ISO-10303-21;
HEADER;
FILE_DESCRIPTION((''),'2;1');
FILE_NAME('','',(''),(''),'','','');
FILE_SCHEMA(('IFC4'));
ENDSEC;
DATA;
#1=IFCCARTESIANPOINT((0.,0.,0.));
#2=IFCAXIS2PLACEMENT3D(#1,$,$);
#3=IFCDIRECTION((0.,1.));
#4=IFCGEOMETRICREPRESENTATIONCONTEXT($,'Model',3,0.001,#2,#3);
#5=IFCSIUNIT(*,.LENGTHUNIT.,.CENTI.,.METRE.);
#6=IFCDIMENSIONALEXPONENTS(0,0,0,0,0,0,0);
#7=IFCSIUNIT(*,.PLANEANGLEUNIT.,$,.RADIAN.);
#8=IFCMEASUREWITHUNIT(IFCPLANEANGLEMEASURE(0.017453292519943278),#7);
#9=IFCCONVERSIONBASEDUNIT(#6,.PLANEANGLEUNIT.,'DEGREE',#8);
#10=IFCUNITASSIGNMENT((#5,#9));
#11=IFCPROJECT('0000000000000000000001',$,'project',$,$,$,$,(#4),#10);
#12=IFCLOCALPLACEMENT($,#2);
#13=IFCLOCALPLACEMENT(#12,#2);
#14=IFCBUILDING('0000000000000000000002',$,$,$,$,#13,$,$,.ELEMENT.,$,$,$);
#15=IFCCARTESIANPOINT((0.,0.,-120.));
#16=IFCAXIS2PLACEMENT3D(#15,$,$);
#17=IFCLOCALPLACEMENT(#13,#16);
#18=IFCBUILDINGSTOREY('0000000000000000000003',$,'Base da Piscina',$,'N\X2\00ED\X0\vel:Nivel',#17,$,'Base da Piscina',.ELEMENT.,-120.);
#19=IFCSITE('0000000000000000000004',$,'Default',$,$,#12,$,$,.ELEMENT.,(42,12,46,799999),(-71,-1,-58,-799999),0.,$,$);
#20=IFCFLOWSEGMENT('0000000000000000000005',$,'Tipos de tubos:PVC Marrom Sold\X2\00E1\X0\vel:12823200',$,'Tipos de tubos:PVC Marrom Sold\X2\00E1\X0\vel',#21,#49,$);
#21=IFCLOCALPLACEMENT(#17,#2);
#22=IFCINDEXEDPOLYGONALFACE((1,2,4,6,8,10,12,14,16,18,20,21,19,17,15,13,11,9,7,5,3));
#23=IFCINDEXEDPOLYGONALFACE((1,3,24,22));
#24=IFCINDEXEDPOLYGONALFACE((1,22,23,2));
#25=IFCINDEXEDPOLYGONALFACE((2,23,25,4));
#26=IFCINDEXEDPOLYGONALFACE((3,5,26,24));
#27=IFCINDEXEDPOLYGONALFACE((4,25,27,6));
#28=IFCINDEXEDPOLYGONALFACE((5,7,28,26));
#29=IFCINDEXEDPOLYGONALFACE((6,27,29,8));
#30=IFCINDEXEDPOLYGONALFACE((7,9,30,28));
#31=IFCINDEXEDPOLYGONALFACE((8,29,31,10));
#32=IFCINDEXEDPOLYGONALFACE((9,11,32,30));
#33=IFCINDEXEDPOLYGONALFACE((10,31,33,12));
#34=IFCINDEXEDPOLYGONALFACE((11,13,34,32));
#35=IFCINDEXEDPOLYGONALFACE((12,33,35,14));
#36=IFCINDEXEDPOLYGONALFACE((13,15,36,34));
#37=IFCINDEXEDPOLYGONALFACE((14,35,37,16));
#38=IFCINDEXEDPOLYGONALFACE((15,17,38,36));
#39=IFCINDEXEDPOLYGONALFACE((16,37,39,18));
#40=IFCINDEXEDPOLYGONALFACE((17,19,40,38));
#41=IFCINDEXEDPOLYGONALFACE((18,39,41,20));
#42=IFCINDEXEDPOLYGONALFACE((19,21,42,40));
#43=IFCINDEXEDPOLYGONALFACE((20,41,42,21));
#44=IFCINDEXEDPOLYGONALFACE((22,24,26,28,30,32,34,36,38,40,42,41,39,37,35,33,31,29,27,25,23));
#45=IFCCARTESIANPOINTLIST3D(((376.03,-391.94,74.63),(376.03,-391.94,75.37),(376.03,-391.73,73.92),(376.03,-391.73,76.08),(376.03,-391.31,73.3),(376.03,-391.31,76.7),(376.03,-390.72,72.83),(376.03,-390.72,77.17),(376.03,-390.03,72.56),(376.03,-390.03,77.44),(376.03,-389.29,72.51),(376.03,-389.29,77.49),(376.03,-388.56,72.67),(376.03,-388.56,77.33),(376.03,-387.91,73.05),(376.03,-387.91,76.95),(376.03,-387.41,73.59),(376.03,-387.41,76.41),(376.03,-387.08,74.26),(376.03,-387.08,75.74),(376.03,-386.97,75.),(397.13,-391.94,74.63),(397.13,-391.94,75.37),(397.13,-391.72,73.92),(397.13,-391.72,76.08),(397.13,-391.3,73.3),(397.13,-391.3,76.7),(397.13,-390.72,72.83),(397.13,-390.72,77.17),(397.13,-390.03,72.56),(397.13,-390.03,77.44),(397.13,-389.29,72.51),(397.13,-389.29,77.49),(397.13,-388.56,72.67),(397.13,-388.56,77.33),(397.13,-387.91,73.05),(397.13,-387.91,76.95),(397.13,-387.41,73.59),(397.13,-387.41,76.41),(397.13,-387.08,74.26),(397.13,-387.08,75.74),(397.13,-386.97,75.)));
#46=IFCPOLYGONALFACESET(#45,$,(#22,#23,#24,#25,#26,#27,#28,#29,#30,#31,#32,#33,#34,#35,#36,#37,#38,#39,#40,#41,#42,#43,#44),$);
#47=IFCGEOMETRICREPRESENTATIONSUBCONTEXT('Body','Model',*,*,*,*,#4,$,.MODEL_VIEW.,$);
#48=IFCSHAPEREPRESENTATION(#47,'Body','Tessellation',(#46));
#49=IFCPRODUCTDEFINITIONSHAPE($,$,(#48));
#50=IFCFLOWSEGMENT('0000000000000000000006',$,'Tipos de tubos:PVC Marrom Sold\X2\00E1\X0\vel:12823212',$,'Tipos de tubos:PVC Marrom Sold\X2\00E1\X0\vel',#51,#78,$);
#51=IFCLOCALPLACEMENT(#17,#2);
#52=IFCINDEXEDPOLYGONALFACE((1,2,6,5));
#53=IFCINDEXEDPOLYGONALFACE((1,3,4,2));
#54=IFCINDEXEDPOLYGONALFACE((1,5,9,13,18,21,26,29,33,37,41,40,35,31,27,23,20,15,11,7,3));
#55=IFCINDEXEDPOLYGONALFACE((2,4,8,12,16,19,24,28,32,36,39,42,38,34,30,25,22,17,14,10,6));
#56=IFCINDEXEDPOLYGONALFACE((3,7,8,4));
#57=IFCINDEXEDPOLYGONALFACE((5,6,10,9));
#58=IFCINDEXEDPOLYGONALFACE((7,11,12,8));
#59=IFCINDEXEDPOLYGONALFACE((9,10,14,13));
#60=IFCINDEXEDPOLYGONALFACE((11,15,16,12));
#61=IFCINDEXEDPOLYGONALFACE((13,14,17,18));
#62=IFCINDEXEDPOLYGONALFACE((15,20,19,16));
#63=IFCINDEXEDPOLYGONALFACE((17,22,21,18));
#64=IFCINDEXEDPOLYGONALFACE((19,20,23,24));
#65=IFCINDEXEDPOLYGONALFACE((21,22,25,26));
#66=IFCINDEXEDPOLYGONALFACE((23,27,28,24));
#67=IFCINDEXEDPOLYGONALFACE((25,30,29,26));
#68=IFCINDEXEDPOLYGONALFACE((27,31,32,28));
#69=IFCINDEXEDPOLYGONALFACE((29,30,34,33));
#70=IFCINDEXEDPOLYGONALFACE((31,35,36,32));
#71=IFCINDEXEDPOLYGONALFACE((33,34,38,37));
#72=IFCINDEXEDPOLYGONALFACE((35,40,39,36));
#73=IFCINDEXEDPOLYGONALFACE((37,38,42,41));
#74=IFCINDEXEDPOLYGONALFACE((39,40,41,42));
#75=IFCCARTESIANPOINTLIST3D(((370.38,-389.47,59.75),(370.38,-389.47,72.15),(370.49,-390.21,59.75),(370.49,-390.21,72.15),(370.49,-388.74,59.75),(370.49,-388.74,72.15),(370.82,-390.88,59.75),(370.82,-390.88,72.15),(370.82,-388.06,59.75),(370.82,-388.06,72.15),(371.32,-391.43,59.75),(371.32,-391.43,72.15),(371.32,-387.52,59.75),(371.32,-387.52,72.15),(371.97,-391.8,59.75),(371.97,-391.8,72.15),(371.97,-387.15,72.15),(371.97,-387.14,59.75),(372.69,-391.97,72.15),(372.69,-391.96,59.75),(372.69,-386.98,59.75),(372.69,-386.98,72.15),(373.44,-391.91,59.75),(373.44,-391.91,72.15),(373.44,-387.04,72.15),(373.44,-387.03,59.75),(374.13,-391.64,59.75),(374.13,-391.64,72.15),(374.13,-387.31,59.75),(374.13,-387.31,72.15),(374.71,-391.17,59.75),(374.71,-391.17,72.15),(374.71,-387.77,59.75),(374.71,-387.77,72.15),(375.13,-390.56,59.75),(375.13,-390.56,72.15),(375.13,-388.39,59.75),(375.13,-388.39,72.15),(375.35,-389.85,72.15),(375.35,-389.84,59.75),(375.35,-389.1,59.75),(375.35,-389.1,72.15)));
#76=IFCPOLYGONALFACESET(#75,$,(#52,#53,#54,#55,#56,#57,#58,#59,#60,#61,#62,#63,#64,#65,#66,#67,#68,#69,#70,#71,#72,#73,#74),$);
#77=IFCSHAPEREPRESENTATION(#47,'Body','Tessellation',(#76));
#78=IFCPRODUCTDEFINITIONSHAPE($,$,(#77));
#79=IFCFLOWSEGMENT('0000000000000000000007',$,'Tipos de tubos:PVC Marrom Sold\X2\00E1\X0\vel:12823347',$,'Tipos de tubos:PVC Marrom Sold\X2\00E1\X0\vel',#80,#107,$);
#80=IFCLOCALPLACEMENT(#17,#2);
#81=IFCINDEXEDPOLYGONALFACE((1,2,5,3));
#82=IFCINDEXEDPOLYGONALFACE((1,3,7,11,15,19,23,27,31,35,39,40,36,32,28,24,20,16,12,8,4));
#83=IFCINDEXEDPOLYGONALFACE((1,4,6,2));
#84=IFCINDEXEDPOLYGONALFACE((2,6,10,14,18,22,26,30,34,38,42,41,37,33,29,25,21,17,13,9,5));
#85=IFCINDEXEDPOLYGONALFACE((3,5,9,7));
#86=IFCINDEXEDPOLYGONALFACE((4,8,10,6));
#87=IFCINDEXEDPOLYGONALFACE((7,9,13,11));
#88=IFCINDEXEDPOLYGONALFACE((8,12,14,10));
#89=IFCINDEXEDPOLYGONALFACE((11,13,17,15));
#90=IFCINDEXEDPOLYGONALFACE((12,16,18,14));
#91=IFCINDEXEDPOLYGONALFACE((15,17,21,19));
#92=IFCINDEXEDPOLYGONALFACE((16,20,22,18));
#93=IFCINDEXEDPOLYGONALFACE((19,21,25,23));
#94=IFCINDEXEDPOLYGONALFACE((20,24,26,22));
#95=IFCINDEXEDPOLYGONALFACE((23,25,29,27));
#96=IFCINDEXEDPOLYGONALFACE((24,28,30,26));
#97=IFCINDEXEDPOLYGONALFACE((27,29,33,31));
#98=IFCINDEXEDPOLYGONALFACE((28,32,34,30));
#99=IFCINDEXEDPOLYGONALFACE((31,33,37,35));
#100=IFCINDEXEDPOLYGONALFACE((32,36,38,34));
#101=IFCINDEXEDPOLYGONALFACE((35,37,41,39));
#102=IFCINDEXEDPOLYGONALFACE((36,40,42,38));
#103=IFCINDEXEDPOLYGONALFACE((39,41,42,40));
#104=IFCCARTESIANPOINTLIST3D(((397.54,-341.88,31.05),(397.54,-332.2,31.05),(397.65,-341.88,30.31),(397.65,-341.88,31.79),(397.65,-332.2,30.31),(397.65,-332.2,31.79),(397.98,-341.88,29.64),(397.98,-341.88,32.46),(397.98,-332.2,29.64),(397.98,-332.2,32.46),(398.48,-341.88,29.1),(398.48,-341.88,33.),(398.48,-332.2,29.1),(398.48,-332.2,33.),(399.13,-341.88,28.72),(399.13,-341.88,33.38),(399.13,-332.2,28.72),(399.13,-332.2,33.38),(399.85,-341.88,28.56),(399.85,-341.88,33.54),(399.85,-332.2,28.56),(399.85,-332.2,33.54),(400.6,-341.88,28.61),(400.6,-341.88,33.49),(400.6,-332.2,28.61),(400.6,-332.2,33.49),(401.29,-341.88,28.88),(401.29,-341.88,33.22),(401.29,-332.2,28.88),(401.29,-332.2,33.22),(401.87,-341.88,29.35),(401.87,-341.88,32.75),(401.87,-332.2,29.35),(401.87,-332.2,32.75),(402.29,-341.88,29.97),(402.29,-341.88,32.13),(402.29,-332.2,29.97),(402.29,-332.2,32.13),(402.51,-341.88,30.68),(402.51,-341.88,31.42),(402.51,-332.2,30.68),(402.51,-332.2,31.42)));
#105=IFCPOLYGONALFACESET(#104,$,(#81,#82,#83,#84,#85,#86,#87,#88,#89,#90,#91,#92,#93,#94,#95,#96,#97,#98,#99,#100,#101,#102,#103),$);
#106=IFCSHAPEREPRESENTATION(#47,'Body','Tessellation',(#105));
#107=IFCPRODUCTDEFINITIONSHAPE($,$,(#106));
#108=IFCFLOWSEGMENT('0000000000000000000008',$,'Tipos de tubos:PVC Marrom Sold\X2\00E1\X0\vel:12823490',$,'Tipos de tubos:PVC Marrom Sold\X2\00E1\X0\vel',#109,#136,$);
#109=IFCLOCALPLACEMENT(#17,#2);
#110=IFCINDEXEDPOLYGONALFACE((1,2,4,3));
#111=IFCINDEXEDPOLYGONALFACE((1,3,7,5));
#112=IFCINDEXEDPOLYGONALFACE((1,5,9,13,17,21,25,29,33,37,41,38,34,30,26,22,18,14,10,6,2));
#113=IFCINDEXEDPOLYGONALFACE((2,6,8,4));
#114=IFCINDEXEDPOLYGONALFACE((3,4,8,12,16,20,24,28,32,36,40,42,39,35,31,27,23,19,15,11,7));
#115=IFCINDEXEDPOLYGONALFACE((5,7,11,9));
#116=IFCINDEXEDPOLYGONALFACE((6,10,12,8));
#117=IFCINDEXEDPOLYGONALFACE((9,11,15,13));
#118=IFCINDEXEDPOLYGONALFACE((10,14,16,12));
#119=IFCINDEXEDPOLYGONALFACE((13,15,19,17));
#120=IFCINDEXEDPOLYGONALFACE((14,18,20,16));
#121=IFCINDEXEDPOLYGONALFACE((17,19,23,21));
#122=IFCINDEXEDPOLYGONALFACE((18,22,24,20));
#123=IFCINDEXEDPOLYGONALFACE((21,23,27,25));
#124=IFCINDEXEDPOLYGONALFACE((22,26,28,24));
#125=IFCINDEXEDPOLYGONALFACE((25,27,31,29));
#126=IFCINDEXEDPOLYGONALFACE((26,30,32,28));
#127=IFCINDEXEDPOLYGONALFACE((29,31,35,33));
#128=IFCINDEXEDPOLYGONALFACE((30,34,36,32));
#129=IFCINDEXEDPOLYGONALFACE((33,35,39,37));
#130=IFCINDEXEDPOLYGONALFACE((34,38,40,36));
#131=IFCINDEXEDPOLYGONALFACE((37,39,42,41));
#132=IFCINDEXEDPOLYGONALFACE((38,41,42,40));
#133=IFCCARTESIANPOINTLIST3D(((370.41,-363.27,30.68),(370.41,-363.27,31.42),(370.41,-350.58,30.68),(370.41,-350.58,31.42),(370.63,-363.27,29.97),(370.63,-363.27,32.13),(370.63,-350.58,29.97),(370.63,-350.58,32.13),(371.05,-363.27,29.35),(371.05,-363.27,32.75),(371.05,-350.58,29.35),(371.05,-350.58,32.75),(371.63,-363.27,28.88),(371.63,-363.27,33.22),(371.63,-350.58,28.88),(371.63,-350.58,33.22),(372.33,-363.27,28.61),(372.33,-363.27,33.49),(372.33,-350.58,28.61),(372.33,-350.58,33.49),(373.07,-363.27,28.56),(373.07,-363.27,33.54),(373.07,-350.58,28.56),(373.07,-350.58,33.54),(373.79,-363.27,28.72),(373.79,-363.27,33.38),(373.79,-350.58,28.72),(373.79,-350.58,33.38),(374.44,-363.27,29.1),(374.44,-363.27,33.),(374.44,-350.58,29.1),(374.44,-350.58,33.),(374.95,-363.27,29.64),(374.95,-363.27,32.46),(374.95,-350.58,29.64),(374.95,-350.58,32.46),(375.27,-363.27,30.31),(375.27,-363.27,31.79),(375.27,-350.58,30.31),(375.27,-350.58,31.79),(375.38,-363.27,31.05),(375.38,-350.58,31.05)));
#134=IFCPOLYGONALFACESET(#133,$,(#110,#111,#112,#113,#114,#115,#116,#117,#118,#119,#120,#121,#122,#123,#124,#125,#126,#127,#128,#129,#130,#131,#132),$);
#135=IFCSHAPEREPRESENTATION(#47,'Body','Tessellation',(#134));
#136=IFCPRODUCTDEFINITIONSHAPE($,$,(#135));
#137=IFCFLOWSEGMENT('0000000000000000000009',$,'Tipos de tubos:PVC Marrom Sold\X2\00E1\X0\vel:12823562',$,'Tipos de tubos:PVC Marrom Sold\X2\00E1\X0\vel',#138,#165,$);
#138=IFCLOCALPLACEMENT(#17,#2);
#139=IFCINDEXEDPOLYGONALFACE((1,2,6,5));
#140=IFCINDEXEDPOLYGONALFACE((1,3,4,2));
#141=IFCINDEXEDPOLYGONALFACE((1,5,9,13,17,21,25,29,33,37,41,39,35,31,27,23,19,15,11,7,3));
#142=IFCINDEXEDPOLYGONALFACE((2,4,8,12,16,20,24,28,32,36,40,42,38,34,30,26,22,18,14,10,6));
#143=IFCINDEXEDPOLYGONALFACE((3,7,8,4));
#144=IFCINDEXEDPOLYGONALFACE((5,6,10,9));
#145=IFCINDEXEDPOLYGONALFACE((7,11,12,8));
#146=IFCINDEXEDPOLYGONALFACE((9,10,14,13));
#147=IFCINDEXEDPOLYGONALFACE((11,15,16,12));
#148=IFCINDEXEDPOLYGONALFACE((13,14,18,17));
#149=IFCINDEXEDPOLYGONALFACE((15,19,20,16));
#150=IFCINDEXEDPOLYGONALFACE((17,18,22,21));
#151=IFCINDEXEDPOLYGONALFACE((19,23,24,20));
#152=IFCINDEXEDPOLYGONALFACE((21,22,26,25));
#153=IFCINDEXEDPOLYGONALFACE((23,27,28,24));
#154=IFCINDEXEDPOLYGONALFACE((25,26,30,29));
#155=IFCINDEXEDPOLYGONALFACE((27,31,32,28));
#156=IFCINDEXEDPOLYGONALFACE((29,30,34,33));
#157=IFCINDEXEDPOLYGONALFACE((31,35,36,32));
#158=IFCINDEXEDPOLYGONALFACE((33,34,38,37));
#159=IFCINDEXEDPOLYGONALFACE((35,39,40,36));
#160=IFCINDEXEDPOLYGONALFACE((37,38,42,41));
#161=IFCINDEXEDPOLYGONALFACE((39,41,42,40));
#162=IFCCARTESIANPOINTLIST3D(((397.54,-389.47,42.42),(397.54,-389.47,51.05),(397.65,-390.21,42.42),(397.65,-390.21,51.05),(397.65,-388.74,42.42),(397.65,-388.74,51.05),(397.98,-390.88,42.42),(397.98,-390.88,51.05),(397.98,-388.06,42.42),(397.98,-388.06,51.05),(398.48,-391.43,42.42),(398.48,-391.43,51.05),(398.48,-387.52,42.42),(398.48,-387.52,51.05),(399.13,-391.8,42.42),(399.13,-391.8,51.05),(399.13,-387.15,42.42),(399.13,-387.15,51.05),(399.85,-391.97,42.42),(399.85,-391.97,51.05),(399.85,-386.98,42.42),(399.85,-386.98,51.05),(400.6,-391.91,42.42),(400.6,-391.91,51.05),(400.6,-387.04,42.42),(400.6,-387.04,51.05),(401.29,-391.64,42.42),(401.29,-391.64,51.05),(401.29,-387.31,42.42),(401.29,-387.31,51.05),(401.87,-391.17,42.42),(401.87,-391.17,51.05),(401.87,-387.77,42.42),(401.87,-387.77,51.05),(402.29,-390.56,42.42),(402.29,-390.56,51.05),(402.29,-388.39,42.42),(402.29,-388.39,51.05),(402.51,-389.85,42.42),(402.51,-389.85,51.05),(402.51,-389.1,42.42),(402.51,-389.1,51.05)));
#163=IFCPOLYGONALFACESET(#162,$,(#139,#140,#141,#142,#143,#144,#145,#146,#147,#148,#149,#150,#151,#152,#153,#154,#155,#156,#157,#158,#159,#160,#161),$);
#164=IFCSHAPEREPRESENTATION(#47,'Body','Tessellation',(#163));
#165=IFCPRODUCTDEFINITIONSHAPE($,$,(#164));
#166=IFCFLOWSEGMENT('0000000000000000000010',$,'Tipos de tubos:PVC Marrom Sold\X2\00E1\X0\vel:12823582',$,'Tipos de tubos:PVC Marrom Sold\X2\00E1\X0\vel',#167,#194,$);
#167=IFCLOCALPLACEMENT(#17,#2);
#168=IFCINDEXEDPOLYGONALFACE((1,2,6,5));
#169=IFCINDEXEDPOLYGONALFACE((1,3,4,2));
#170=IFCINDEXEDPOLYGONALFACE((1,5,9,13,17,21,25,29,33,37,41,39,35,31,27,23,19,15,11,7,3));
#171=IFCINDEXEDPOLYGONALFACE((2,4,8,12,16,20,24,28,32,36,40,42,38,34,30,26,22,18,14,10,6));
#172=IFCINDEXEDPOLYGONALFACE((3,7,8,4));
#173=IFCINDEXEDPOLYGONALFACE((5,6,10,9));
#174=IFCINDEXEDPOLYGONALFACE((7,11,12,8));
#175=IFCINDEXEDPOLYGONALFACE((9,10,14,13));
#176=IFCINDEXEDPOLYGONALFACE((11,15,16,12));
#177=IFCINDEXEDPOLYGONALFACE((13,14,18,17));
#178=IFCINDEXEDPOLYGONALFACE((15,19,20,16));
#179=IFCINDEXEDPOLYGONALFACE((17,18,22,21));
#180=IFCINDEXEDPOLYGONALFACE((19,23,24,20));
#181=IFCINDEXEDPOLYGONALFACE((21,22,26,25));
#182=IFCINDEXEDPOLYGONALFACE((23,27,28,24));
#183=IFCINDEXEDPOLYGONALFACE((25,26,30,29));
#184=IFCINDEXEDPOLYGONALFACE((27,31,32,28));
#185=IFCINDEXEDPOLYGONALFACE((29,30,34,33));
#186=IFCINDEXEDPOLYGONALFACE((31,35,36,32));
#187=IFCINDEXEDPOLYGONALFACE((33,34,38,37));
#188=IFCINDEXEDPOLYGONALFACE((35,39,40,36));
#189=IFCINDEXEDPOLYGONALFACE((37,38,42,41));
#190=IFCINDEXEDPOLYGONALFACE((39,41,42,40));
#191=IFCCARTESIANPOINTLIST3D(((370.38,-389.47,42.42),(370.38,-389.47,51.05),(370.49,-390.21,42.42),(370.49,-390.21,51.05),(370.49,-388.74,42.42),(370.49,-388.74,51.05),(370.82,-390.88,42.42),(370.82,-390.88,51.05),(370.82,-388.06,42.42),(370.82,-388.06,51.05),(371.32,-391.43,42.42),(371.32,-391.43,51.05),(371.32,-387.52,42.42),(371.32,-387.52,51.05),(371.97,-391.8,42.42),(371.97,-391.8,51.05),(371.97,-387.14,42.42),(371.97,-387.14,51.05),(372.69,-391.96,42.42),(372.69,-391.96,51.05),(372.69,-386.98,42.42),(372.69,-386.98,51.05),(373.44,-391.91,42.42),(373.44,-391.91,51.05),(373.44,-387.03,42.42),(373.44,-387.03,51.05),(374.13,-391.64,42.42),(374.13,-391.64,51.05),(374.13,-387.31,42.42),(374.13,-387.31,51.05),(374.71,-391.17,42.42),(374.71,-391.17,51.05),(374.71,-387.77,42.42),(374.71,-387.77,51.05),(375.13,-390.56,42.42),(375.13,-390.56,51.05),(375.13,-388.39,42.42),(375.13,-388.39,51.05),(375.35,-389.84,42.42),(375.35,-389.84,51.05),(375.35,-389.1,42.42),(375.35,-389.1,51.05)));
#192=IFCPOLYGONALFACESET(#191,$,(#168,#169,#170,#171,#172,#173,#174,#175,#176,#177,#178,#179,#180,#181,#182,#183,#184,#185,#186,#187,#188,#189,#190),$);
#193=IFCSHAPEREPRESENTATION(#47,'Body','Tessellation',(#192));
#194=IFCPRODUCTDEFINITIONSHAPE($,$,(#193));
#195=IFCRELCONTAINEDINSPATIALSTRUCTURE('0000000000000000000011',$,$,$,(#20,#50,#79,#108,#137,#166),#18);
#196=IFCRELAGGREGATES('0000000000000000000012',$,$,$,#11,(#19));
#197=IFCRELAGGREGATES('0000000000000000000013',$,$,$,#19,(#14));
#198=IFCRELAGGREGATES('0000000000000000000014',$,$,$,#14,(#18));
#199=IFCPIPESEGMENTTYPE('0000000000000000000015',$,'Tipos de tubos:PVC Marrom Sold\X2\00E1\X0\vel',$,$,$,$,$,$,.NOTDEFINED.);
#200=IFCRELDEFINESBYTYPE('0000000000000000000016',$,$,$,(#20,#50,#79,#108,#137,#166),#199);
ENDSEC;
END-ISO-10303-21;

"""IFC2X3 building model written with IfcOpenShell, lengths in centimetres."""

from ifc_helpers import new_model, entity, si_unit, converted_unit, direction, frame, frame_2d, origin, origin_2d_with_axis, place, context, subcontext, project, spatial, circle, extrude, type_object, element, save


model = new_model("IFC2X3")

# Units and contexts
model_context = context("Model", 3, precision=0.001, world=origin(), true_north=direction((0.0, 1.0)))
body_context = subcontext(model_context, "Body", "Model", "MODEL_VIEW")
ifc_project = project(units=[si_unit("LENGTHUNIT", "METRE", prefix="CENTI"), converted_unit("PLANEANGLEUNIT", "DEGREE", entity("IfcPlaneAngleMeasure", 0.017453292519943278), si_unit("PLANEANGLEUNIT", "RADIAN"), dimensions=[0, 0, 0, 0, 0, 0, 0])], contexts=[model_context])

# Site, building, storey
site_placement = place(None, origin())
site = spatial("IfcSite", under=ifc_project, at=site_placement, Name="Default", CompositionType="ELEMENT", RefLatitude=(42, 12, 46, 799999), RefLongitude=(-71, -1, -58, -799999), RefElevation=0.0)
building_placement = place(site_placement, origin())
building = spatial("IfcBuilding", under=site, at=building_placement, CompositionType="ELEMENT")
storey_placement = place(building_placement, frame((0.0, 0.0, -120.0)))
storey = spatial("IfcBuildingStorey", under=building, at=storey_placement, Name="Base da Piscina", ObjectType="Nível:Nivel", LongName="Base da Piscina", CompositionType="ELEMENT", Elevation=-120.0)

# Flow segments
pipe_segment_type = type_object("IfcPipeSegmentType", Name="Tipos de tubos:PVC Marrom Soldável", PredefinedType="NOTDEFINED")
flow_segment_1_placement = place(storey_placement, origin())
element("IfcFlowSegment", 1, at=flow_segment_1_placement, inside=storey, type_object=pipe_segment_type, Name="Tipos de tubos:PVC Marrom Soldável:12823200", ObjectType="Tipos de tubos:PVC Marrom Soldável", context=body_context, shape_type="SweptSolid", body=[
    extrude(circle(Radius=2.5, at=origin_2d_with_axis()), frame((376.03, -389.47, 75.0), z_axis=(1.0, 0.000024, 0.0), x_axis=(-0.000024, 1.0, 0.0)), (0.0, 0.0, 1.0), 21.1),
])
flow_segment_2_placement = place(storey_placement, origin())
element("IfcFlowSegment", 2, at=flow_segment_2_placement, inside=storey, type_object=pipe_segment_type, Name="Tipos de tubos:PVC Marrom Soldável:12823212", ObjectType="Tipos de tubos:PVC Marrom Soldável", context=body_context, shape_type="SweptSolid", body=[
    extrude(circle(Radius=2.5, at=frame_2d((0.0, 0.0), x_axis=(1.0, 0.0))), frame((372.88, -389.47, 59.75), z_axis=(0.0, -0.000075, 1.0), x_axis=(-1.0, 0.0, 0.0)), (0.0, 0.0, 1.0), 12.4),
])
flow_segment_3_placement = place(storey_placement, origin())
element("IfcFlowSegment", 3, at=flow_segment_3_placement, inside=storey, type_object=pipe_segment_type, Name="Tipos de tubos:PVC Marrom Soldável:12823347", ObjectType="Tipos de tubos:PVC Marrom Soldável", context=body_context, shape_type="SweptSolid", body=[
    extrude(circle(Radius=2.5, at=origin_2d_with_axis()), frame((400.04, -341.88, 31.05), z_axis=(0.0, 1.0, 0.0), x_axis=(-1.0, 0.0, 0.0)), (0.0, 0.0, 1.0), 9.68),
])
flow_segment_4_placement = place(storey_placement, origin())
element("IfcFlowSegment", 4, at=flow_segment_4_placement, inside=storey, type_object=pipe_segment_type, Name="Tipos de tubos:PVC Marrom Soldável:12823490", ObjectType="Tipos de tubos:PVC Marrom Soldável", context=body_context, shape_type="SweptSolid", body=[
    extrude(circle(Radius=2.5, at=origin_2d_with_axis()), frame((372.88, -363.27, 31.05), z_axis=(0.0, 1.0, 0.0), x_axis=(1.0, 0.0, 0.0)), (0.0, 0.0, 1.0), 12.69),
])
flow_segment_5_placement = place(storey_placement, origin())
element("IfcFlowSegment", 5, at=flow_segment_5_placement, inside=storey, type_object=pipe_segment_type, Name="Tipos de tubos:PVC Marrom Soldável:12823562", ObjectType="Tipos de tubos:PVC Marrom Soldável", context=body_context, shape_type="SweptSolid", body=[
    extrude(circle(Radius=2.5, at=frame_2d((0.0, 0.0), x_axis=(1.0, 0.0))), frame((400.04, -389.47, 42.42), z_axis=(0.0, 0.0, 1.0), x_axis=(-1.0, 0.0, 0.0)), (0.0, 0.0, 1.0), 8.63),
])
flow_segment_6_placement = place(storey_placement, origin())
element("IfcFlowSegment", 6, at=flow_segment_6_placement, inside=storey, type_object=pipe_segment_type, Name="Tipos de tubos:PVC Marrom Soldável:12823582", ObjectType="Tipos de tubos:PVC Marrom Soldável", context=body_context, shape_type="SweptSolid", body=[
    extrude(circle(Radius=2.5, at=frame_2d((0.0, 0.0), x_axis=(1.0, 0.0))), frame((372.88, -389.47, 42.42), z_axis=(0.0, 0.0, 1.0), x_axis=(-1.0, 0.0, 0.0)), (0.0, 0.0, 1.0), 8.63),
])

save(model, "model.ifc")
